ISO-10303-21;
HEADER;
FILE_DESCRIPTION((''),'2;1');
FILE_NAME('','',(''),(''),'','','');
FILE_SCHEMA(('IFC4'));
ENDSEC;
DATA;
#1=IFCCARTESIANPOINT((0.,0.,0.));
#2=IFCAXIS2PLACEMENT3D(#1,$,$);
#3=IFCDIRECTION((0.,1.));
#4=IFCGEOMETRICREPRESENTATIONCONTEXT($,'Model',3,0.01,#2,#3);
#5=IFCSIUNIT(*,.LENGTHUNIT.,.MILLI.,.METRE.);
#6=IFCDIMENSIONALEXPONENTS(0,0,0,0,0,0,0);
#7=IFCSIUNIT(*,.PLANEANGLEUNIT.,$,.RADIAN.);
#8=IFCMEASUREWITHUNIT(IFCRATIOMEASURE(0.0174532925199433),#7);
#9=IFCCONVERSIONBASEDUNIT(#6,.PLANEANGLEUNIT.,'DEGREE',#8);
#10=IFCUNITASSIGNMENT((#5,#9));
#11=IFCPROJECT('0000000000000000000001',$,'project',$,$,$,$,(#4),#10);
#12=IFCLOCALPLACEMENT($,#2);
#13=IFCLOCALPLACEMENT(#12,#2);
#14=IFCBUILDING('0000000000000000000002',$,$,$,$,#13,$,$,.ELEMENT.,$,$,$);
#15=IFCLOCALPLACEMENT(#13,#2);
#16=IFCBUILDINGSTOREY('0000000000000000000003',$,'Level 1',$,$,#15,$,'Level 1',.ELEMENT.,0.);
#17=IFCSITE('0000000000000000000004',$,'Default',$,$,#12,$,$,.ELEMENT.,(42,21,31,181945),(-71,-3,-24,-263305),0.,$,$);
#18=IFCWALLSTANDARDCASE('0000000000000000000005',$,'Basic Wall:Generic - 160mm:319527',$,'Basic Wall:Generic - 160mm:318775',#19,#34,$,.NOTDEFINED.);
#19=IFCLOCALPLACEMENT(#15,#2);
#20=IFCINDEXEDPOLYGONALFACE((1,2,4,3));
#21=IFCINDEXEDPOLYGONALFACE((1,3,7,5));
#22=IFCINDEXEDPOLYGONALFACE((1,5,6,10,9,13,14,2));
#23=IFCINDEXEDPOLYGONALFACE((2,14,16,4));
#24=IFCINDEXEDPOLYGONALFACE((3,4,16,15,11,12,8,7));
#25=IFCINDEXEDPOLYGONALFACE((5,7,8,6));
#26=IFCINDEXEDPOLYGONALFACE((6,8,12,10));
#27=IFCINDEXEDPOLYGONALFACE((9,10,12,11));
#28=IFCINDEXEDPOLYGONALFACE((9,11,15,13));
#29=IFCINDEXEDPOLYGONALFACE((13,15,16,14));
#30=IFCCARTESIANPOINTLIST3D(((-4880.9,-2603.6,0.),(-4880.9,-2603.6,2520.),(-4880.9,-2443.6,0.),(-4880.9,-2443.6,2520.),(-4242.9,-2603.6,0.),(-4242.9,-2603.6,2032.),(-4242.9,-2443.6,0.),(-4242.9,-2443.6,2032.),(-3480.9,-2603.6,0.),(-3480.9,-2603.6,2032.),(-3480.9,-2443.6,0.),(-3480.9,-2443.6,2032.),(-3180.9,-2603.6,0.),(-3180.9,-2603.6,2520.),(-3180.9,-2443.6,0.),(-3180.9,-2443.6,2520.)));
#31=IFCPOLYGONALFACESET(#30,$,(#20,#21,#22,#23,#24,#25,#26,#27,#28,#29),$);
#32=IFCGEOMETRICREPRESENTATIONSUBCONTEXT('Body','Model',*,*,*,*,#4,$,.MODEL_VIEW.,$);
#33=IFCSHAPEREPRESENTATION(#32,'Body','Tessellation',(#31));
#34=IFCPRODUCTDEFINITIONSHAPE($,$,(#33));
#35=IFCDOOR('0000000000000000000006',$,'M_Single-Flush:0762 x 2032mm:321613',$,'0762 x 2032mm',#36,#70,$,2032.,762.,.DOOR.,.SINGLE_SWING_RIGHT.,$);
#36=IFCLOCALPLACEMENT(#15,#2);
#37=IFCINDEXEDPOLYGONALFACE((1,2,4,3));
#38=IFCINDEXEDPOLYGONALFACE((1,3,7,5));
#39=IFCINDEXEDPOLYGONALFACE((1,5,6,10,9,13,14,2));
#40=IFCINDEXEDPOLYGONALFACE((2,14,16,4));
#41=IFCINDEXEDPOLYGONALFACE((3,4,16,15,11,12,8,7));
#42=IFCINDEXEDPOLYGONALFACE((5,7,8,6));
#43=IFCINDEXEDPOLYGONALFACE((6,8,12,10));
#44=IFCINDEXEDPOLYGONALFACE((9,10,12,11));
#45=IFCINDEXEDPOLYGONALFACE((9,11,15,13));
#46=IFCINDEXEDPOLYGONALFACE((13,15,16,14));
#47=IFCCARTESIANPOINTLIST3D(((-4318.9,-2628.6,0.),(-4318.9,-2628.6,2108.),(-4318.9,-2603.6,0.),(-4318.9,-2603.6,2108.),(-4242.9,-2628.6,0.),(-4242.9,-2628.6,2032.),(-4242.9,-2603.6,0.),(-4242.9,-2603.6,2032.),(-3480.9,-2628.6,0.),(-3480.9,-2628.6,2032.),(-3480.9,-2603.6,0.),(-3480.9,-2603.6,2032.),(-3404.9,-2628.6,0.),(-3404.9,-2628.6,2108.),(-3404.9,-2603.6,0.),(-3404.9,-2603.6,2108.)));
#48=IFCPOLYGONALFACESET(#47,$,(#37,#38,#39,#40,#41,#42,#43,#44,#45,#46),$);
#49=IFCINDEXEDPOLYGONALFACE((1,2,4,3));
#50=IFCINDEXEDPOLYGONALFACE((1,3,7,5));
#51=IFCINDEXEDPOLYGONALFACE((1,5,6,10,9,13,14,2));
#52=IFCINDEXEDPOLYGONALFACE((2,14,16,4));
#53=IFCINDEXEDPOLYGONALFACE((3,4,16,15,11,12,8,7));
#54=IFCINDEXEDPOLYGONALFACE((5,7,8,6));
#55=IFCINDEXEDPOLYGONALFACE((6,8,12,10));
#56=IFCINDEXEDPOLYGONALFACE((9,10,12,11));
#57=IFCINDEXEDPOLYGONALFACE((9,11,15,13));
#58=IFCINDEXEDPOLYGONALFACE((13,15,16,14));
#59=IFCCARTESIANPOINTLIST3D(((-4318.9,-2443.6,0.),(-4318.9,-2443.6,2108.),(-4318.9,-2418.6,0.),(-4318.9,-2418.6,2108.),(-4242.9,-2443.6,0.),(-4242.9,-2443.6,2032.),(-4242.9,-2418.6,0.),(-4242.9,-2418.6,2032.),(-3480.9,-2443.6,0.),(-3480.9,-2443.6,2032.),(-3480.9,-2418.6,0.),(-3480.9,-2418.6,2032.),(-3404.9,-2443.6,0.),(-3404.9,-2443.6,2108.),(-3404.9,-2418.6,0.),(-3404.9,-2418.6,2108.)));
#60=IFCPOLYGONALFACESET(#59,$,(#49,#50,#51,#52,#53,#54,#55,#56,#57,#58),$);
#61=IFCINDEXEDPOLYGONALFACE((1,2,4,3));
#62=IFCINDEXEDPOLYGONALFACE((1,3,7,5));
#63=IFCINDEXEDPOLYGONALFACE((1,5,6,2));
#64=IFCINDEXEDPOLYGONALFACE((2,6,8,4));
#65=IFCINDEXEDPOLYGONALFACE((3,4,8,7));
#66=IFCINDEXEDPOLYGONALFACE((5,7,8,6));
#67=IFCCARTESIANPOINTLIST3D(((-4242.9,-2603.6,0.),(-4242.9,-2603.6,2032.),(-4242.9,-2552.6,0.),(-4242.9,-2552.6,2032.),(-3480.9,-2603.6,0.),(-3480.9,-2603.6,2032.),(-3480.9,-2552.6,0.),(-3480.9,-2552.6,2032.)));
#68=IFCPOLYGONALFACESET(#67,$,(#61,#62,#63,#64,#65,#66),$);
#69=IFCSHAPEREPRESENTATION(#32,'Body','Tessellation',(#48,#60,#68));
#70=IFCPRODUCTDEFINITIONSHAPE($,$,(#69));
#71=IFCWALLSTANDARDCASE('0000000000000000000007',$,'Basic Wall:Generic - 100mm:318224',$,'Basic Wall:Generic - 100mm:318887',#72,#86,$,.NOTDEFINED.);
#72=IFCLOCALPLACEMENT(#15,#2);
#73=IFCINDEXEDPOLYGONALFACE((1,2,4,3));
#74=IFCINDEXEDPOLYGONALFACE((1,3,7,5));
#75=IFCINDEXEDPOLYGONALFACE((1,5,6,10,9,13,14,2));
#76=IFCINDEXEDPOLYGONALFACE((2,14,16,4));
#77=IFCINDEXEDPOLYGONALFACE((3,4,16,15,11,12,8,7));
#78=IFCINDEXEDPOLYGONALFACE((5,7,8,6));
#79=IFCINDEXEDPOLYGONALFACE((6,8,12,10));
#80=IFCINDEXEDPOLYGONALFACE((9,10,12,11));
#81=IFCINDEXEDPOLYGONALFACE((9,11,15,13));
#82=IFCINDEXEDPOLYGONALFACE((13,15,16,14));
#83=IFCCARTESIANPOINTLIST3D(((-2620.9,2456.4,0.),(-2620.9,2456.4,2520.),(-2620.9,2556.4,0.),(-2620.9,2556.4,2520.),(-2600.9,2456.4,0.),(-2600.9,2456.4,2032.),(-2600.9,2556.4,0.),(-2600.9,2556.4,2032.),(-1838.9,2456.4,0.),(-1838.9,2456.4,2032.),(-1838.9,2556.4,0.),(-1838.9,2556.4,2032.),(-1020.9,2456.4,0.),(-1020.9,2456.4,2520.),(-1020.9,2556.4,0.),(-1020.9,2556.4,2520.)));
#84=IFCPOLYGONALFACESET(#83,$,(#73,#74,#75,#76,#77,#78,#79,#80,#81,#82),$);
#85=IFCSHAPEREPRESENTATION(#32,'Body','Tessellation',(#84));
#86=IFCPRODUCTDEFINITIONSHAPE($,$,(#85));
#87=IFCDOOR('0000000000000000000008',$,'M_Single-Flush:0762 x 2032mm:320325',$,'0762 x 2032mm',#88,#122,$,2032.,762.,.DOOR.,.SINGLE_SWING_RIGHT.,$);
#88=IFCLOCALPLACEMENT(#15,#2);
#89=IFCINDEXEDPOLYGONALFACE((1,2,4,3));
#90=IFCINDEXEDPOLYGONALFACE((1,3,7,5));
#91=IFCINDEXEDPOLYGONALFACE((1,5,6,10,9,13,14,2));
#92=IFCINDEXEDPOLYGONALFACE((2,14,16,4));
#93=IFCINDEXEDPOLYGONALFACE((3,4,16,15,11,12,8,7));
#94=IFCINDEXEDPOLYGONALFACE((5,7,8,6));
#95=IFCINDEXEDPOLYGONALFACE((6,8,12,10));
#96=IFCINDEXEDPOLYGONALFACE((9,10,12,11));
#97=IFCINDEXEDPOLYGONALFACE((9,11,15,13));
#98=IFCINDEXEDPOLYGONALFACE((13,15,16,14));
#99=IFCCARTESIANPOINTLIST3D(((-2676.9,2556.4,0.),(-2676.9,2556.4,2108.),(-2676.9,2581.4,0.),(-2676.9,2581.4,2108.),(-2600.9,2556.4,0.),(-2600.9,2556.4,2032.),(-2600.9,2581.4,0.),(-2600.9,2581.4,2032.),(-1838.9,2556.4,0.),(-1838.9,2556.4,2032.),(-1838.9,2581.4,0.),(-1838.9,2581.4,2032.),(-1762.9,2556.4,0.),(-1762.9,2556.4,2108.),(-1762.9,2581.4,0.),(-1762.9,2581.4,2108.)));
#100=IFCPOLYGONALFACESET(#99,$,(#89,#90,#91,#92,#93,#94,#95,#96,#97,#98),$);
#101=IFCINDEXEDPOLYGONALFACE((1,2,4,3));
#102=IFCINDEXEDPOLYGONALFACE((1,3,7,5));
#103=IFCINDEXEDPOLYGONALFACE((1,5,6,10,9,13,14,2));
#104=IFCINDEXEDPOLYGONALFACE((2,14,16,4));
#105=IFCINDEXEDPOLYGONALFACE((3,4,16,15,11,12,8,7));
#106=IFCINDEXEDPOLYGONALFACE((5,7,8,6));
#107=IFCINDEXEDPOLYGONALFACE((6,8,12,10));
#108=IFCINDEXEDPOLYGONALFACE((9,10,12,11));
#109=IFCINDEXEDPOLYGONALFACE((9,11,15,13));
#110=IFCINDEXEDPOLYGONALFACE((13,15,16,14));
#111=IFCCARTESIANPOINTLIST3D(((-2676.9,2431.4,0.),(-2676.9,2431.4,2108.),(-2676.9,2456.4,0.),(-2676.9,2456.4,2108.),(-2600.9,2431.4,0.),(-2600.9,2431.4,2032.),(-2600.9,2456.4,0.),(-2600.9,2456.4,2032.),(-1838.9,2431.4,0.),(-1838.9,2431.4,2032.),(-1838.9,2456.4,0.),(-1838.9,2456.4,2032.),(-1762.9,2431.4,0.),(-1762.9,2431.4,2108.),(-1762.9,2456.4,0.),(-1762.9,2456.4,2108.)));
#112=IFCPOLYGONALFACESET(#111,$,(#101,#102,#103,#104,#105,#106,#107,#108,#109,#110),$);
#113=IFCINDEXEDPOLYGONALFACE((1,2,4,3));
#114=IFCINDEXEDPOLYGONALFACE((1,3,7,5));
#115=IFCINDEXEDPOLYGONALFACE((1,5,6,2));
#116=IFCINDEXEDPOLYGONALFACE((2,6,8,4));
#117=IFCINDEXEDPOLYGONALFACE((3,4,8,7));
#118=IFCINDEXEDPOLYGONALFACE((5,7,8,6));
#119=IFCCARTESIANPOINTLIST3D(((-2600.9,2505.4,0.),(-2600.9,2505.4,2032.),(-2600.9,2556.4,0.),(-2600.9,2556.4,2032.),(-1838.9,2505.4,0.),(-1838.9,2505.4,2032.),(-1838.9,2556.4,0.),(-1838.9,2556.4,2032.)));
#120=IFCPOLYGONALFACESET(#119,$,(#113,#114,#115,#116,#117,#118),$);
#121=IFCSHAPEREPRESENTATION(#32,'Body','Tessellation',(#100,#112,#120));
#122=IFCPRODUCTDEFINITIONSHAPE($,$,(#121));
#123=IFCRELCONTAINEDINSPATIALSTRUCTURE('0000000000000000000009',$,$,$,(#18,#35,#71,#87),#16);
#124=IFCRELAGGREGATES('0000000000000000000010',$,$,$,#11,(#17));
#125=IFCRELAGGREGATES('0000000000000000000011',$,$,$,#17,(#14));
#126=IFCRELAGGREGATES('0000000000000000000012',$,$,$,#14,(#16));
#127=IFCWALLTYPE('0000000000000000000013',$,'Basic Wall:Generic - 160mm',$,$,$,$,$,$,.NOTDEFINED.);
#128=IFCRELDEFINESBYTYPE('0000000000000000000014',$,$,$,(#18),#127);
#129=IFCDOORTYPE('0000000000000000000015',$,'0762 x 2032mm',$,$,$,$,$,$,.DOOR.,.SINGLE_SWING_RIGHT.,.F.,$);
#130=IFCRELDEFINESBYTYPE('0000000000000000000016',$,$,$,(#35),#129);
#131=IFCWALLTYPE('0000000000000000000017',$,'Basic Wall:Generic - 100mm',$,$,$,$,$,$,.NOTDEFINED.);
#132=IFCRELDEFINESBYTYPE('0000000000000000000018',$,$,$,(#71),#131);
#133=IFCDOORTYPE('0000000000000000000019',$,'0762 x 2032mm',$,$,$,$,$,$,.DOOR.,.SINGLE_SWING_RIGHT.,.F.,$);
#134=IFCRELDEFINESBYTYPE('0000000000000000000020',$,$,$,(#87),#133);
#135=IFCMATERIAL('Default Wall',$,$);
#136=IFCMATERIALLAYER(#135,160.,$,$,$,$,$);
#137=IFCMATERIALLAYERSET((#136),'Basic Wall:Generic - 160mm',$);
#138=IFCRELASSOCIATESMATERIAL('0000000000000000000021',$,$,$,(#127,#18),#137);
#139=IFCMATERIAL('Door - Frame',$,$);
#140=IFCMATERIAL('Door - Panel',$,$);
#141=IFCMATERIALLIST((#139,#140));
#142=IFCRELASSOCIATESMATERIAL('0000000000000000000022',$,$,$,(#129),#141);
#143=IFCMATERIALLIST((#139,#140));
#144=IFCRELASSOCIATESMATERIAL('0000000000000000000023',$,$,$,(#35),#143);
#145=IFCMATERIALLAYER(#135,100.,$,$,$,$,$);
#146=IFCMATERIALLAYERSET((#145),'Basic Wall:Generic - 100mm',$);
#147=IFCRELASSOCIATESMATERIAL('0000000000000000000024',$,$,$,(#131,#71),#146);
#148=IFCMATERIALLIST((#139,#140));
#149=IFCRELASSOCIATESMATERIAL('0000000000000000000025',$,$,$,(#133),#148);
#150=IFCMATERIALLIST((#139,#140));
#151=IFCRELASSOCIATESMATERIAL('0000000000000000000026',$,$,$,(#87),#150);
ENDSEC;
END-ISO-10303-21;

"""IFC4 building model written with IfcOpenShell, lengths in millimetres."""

from ifc_helpers import new_model, entity, si_unit, converted_unit, direction, frame, frame_2d, origin, origin_2d_with_axis, place, context, subcontext, project, spatial, polyline, rectangle, outline, extrude, source, transform, mapped, material, material_list, layer, layer_set, layer_usage, type_object, type_shapes, element, fill, save


model = new_model("IFC4")

# Units and contexts
model_context = context("Model", 3, precision=0.01, world=origin(), true_north=direction((0.0, 1.0)))
body_context = subcontext(model_context, "Body", "Model", "MODEL_VIEW")
ifc_project = project(units=[si_unit("LENGTHUNIT", "METRE", prefix="MILLI"), converted_unit("PLANEANGLEUNIT", "DEGREE", entity("IfcRatioMeasure", 0.0174532925199433), si_unit("PLANEANGLEUNIT", "RADIAN"), dimensions=[0, 0, 0, 0, 0, 0, 0])], contexts=[model_context])

# Site, building, storey
site_placement = place(None, origin())
site = spatial("IfcSite", under=ifc_project, at=site_placement, Name="Default", CompositionType="ELEMENT", RefLatitude=(42, 21, 31, 181945), RefLongitude=(-71, -3, -24, -263305), RefElevation=0.0)
building_placement = place(site_placement, origin())
building = spatial("IfcBuilding", under=site, at=building_placement, CompositionType="ELEMENT")
storey_placement = place(building_placement, origin())
storey = spatial("IfcBuildingStorey", under=building, at=storey_placement, Name="Level 1", LongName="Level 1", CompositionType="ELEMENT", Elevation=0.0)

# Shared definitions
ifc_material_1 = material(Name="Default Wall")

# Shared definitions
ifc_layer_1 = layer(ifc_material_1, 160.0)
ifc_layer_set_1 = layer_set([ifc_layer_1], Name="Basic Wall:Generic - 160mm")
wall_type_1 = type_object("IfcWallType", Name="Basic Wall:Generic - 160mm", PredefinedType="NOTDEFINED", material=ifc_layer_set_1)
ifc_material_2 = material(Name="Door - Frame")
ifc_material_3 = material(Name="Door - Panel")

# Walls, openings, doors
ifc_layer_usage_1 = layer_usage(ifc_layer_set_1, "AXIS2", "NEGATIVE", 80.0)
wall_1_placement = place(storey_placement, frame((-4880.9, -2523.6, 0.0)))
wall_1 = element("IfcWallStandardCase", 1, at=wall_1_placement, inside=storey, type_object=wall_type_1, material=ifc_layer_usage_1, Name="Basic Wall:Generic - 160mm:319527", ObjectType="Basic Wall:Generic - 160mm:318775", PredefinedType="NOTDEFINED", context=body_context, shape_type="SweptSolid", body=[
    extrude(rectangle(XDim=1700.0, YDim=160.0, at=frame_2d((850.0, 0.0), x_axis=(-1.0, 0.0))), origin(), (0.0, 0.0, 1.0), 2520.0),
])
opening_1_placement = place(wall_1_placement, frame((1400.0, 80.0, 0.0)))
opening_1 = element("IfcOpeningElement", 2, at=opening_1_placement, cuts=wall_1, ObjectType="Opening", PredefinedType="OPENING", context=body_context, shape_type="SweptSolid", body=[
    extrude(rectangle(XDim=762.0, YDim=2032.0, at=frame_2d((1016.0, 381.0), x_axis=(0.0, 1.0))), frame((0.0, 0.0, 0.0), z_axis=(0.0, -1.0, 0.0), x_axis=(0.0, 0.0, 1.0)), (0.0, 0.0, 1.0), 160.0),
])
ifc_material_list_1 = material_list([ifc_material_2, ifc_material_3])
ifc_material_list_2 = material_list([ifc_material_2, ifc_material_3])
door_type_1 = type_object("IfcDoorType", Name="0762 x 2032mm", OperationType="SINGLE_SWING_RIGHT", ParameterTakesPrecedence=False, PredefinedType="DOOR", material=ifc_material_list_2)
shared_shape_1 = source(origin(), body_context, "Body", "SweptSolid", [
    extrude(outline(polyline([(-457.0, -1073.0), (457.0, -1073.0), (457.0, 1035.0), (381.0, 1035.0), (381.0, -997.0), (-381.0, -997.0), (-381.0, 1035.0), (-457.0, 1035.0), (-457.0, -1073.0)])), frame((381.0, 160.0, 1035.0), z_axis=(0.0, 1.0, 0.0), x_axis=(1.0, 0.0, 0.0)), (0.0, 0.0, 1.0), 25.0),
    extrude(outline(polyline([(-1073.0, -457.0), (1035.0, -457.0), (1035.0, -381.0), (-997.0, -381.0), (-997.0, 381.0), (1035.0, 381.0), (1035.0, 457.0), (-1073.0, 457.0), (-1073.0, -457.0)])), frame((381.0, -25.0, 1035.0), z_axis=(0.0, 1.0, 0.0), x_axis=(0.0, 0.0, -1.0)), (0.0, 0.0, 1.0), 25.0),
    extrude(rectangle(XDim=51.0, YDim=762.0, at=frame_2d((0.0, 0.0), x_axis=(1.0, 0.0))), frame((381.0, 134.5, 0.0), z_axis=(0.0, 0.0, 1.0), x_axis=(0.0, 1.0, 0.0)), (0.0, 0.0, 1.0), 2032.0),
])
type_shapes(door_type_1, [shared_shape_1])
door_1_placement = place(opening_1_placement, frame((0.0, 0.0, 0.0), z_axis=(0.0, 0.0, 1.0), x_axis=(-1.0, 0.0, 0.0)))
door_1 = element("IfcDoor", 3, at=door_1_placement, inside=storey, type_object=door_type_1, material=ifc_material_list_1, Name="M_Single-Flush:0762 x 2032mm:321613", ObjectType="0762 x 2032mm", OperationType="SINGLE_SWING_RIGHT", OverallHeight=2032.0, OverallWidth=762.0, PredefinedType="DOOR", context=body_context, shape_type="MappedRepresentation", body=[
    mapped(shared_shape_1, transform((0.0, 0.0, 0.0), scale=1.0)),
])
fill(opening_1, door_1)
ifc_layer_2 = layer(ifc_material_1, 100.0)
ifc_layer_set_2 = layer_set([ifc_layer_2], Name="Basic Wall:Generic - 100mm")
ifc_layer_usage_2 = layer_usage(ifc_layer_set_2, "AXIS2", "POSITIVE", -50.0)
wall_type_2 = type_object("IfcWallType", Name="Basic Wall:Generic - 100mm", PredefinedType="NOTDEFINED", material=ifc_layer_set_2)
wall_2_placement = place(storey_placement, frame((-1020.9, 2506.4, 0.0), z_axis=(0.0, 0.0, 1.0), x_axis=(-1.0, 0.0, 0.0)))
wall_2 = element("IfcWallStandardCase", 4, at=wall_2_placement, inside=storey, type_object=wall_type_2, material=ifc_layer_usage_2, Name="Basic Wall:Generic - 100mm:318224", ObjectType="Basic Wall:Generic - 100mm:318887", PredefinedType="NOTDEFINED", context=body_context, shape_type="SweptSolid", body=[
    extrude(rectangle(XDim=1600.0, YDim=100.0, at=frame_2d((800.0, 0.0), x_axis=(-1.0, 0.0))), origin(), (0.0, 0.0, 1.0), 2520.0),
])
opening_2_placement = place(wall_2_placement, frame((1580.0, 50.0, 0.0)))
opening_2 = element("IfcOpeningElement", 5, at=opening_2_placement, cuts=wall_2, ObjectType="Opening", PredefinedType="OPENING", context=body_context, shape_type="SweptSolid", body=[
    extrude(rectangle(XDim=762.0, YDim=2032.0, at=frame_2d((1016.0, 381.0), x_axis=(0.0, 1.0))), frame((0.0, 0.0, 0.0), z_axis=(0.0, -1.0, 0.0), x_axis=(0.0, 0.0, 1.0)), (0.0, 0.0, 1.0), 100.0),
])
ifc_material_list_3 = material_list([ifc_material_2, ifc_material_3])
ifc_material_list_4 = material_list([ifc_material_2, ifc_material_3])
door_type_2 = type_object("IfcDoorType", Name="0762 x 2032mm", OperationType="SINGLE_SWING_RIGHT", ParameterTakesPrecedence=False, PredefinedType="DOOR", material=ifc_material_list_4)
shared_shape_2 = source(origin(), body_context, "Body", "SweptSolid", [
    extrude(outline(polyline([(-457.0, -1073.0), (457.0, -1073.0), (457.0, 1035.0), (381.0, 1035.0), (381.0, -997.0), (-381.0, -997.0), (-381.0, 1035.0), (-457.0, 1035.0), (-457.0, -1073.0)])), frame((381.0, 100.0, 1035.0), z_axis=(0.0, 1.0, 0.0), x_axis=(1.0, 0.0, 0.0)), (0.0, 0.0, 1.0), 25.0),
    extrude(outline(polyline([(-1073.0, -457.0), (1035.0, -457.0), (1035.0, -381.0), (-997.0, -381.0), (-997.0, 381.0), (1035.0, 381.0), (1035.0, 457.0), (-1073.0, 457.0), (-1073.0, -457.0)])), frame((381.0, -25.0, 1035.0), z_axis=(0.0, 1.0, 0.0), x_axis=(0.0, 0.0, -1.0)), (0.0, 0.0, 1.0), 25.0),
    extrude(rectangle(XDim=51.0, YDim=762.0, at=origin_2d_with_axis()), frame((381.0, 74.5, 0.0), z_axis=(0.0, 0.0, 1.0), x_axis=(0.0, 1.0, 0.0)), (0.0, 0.0, 1.0), 2032.0),
])
type_shapes(door_type_2, [shared_shape_2])
door_2_placement = place(opening_2_placement, frame((0.0, 0.0, 0.0), z_axis=(0.0, 0.0, 1.0), x_axis=(-1.0, 0.0, 0.0)))
door_2 = element("IfcDoor", 6, at=door_2_placement, inside=storey, type_object=door_type_2, material=ifc_material_list_3, Name="M_Single-Flush:0762 x 2032mm:320325", ObjectType="0762 x 2032mm", OperationType="SINGLE_SWING_RIGHT", OverallHeight=2032.0, OverallWidth=762.0, PredefinedType="DOOR", context=body_context, shape_type="MappedRepresentation", body=[
    mapped(shared_shape_2, transform((0.0, 0.0, 0.0), scale=1.0)),
])
fill(opening_2, door_2)

save(model, "model.ifc")
